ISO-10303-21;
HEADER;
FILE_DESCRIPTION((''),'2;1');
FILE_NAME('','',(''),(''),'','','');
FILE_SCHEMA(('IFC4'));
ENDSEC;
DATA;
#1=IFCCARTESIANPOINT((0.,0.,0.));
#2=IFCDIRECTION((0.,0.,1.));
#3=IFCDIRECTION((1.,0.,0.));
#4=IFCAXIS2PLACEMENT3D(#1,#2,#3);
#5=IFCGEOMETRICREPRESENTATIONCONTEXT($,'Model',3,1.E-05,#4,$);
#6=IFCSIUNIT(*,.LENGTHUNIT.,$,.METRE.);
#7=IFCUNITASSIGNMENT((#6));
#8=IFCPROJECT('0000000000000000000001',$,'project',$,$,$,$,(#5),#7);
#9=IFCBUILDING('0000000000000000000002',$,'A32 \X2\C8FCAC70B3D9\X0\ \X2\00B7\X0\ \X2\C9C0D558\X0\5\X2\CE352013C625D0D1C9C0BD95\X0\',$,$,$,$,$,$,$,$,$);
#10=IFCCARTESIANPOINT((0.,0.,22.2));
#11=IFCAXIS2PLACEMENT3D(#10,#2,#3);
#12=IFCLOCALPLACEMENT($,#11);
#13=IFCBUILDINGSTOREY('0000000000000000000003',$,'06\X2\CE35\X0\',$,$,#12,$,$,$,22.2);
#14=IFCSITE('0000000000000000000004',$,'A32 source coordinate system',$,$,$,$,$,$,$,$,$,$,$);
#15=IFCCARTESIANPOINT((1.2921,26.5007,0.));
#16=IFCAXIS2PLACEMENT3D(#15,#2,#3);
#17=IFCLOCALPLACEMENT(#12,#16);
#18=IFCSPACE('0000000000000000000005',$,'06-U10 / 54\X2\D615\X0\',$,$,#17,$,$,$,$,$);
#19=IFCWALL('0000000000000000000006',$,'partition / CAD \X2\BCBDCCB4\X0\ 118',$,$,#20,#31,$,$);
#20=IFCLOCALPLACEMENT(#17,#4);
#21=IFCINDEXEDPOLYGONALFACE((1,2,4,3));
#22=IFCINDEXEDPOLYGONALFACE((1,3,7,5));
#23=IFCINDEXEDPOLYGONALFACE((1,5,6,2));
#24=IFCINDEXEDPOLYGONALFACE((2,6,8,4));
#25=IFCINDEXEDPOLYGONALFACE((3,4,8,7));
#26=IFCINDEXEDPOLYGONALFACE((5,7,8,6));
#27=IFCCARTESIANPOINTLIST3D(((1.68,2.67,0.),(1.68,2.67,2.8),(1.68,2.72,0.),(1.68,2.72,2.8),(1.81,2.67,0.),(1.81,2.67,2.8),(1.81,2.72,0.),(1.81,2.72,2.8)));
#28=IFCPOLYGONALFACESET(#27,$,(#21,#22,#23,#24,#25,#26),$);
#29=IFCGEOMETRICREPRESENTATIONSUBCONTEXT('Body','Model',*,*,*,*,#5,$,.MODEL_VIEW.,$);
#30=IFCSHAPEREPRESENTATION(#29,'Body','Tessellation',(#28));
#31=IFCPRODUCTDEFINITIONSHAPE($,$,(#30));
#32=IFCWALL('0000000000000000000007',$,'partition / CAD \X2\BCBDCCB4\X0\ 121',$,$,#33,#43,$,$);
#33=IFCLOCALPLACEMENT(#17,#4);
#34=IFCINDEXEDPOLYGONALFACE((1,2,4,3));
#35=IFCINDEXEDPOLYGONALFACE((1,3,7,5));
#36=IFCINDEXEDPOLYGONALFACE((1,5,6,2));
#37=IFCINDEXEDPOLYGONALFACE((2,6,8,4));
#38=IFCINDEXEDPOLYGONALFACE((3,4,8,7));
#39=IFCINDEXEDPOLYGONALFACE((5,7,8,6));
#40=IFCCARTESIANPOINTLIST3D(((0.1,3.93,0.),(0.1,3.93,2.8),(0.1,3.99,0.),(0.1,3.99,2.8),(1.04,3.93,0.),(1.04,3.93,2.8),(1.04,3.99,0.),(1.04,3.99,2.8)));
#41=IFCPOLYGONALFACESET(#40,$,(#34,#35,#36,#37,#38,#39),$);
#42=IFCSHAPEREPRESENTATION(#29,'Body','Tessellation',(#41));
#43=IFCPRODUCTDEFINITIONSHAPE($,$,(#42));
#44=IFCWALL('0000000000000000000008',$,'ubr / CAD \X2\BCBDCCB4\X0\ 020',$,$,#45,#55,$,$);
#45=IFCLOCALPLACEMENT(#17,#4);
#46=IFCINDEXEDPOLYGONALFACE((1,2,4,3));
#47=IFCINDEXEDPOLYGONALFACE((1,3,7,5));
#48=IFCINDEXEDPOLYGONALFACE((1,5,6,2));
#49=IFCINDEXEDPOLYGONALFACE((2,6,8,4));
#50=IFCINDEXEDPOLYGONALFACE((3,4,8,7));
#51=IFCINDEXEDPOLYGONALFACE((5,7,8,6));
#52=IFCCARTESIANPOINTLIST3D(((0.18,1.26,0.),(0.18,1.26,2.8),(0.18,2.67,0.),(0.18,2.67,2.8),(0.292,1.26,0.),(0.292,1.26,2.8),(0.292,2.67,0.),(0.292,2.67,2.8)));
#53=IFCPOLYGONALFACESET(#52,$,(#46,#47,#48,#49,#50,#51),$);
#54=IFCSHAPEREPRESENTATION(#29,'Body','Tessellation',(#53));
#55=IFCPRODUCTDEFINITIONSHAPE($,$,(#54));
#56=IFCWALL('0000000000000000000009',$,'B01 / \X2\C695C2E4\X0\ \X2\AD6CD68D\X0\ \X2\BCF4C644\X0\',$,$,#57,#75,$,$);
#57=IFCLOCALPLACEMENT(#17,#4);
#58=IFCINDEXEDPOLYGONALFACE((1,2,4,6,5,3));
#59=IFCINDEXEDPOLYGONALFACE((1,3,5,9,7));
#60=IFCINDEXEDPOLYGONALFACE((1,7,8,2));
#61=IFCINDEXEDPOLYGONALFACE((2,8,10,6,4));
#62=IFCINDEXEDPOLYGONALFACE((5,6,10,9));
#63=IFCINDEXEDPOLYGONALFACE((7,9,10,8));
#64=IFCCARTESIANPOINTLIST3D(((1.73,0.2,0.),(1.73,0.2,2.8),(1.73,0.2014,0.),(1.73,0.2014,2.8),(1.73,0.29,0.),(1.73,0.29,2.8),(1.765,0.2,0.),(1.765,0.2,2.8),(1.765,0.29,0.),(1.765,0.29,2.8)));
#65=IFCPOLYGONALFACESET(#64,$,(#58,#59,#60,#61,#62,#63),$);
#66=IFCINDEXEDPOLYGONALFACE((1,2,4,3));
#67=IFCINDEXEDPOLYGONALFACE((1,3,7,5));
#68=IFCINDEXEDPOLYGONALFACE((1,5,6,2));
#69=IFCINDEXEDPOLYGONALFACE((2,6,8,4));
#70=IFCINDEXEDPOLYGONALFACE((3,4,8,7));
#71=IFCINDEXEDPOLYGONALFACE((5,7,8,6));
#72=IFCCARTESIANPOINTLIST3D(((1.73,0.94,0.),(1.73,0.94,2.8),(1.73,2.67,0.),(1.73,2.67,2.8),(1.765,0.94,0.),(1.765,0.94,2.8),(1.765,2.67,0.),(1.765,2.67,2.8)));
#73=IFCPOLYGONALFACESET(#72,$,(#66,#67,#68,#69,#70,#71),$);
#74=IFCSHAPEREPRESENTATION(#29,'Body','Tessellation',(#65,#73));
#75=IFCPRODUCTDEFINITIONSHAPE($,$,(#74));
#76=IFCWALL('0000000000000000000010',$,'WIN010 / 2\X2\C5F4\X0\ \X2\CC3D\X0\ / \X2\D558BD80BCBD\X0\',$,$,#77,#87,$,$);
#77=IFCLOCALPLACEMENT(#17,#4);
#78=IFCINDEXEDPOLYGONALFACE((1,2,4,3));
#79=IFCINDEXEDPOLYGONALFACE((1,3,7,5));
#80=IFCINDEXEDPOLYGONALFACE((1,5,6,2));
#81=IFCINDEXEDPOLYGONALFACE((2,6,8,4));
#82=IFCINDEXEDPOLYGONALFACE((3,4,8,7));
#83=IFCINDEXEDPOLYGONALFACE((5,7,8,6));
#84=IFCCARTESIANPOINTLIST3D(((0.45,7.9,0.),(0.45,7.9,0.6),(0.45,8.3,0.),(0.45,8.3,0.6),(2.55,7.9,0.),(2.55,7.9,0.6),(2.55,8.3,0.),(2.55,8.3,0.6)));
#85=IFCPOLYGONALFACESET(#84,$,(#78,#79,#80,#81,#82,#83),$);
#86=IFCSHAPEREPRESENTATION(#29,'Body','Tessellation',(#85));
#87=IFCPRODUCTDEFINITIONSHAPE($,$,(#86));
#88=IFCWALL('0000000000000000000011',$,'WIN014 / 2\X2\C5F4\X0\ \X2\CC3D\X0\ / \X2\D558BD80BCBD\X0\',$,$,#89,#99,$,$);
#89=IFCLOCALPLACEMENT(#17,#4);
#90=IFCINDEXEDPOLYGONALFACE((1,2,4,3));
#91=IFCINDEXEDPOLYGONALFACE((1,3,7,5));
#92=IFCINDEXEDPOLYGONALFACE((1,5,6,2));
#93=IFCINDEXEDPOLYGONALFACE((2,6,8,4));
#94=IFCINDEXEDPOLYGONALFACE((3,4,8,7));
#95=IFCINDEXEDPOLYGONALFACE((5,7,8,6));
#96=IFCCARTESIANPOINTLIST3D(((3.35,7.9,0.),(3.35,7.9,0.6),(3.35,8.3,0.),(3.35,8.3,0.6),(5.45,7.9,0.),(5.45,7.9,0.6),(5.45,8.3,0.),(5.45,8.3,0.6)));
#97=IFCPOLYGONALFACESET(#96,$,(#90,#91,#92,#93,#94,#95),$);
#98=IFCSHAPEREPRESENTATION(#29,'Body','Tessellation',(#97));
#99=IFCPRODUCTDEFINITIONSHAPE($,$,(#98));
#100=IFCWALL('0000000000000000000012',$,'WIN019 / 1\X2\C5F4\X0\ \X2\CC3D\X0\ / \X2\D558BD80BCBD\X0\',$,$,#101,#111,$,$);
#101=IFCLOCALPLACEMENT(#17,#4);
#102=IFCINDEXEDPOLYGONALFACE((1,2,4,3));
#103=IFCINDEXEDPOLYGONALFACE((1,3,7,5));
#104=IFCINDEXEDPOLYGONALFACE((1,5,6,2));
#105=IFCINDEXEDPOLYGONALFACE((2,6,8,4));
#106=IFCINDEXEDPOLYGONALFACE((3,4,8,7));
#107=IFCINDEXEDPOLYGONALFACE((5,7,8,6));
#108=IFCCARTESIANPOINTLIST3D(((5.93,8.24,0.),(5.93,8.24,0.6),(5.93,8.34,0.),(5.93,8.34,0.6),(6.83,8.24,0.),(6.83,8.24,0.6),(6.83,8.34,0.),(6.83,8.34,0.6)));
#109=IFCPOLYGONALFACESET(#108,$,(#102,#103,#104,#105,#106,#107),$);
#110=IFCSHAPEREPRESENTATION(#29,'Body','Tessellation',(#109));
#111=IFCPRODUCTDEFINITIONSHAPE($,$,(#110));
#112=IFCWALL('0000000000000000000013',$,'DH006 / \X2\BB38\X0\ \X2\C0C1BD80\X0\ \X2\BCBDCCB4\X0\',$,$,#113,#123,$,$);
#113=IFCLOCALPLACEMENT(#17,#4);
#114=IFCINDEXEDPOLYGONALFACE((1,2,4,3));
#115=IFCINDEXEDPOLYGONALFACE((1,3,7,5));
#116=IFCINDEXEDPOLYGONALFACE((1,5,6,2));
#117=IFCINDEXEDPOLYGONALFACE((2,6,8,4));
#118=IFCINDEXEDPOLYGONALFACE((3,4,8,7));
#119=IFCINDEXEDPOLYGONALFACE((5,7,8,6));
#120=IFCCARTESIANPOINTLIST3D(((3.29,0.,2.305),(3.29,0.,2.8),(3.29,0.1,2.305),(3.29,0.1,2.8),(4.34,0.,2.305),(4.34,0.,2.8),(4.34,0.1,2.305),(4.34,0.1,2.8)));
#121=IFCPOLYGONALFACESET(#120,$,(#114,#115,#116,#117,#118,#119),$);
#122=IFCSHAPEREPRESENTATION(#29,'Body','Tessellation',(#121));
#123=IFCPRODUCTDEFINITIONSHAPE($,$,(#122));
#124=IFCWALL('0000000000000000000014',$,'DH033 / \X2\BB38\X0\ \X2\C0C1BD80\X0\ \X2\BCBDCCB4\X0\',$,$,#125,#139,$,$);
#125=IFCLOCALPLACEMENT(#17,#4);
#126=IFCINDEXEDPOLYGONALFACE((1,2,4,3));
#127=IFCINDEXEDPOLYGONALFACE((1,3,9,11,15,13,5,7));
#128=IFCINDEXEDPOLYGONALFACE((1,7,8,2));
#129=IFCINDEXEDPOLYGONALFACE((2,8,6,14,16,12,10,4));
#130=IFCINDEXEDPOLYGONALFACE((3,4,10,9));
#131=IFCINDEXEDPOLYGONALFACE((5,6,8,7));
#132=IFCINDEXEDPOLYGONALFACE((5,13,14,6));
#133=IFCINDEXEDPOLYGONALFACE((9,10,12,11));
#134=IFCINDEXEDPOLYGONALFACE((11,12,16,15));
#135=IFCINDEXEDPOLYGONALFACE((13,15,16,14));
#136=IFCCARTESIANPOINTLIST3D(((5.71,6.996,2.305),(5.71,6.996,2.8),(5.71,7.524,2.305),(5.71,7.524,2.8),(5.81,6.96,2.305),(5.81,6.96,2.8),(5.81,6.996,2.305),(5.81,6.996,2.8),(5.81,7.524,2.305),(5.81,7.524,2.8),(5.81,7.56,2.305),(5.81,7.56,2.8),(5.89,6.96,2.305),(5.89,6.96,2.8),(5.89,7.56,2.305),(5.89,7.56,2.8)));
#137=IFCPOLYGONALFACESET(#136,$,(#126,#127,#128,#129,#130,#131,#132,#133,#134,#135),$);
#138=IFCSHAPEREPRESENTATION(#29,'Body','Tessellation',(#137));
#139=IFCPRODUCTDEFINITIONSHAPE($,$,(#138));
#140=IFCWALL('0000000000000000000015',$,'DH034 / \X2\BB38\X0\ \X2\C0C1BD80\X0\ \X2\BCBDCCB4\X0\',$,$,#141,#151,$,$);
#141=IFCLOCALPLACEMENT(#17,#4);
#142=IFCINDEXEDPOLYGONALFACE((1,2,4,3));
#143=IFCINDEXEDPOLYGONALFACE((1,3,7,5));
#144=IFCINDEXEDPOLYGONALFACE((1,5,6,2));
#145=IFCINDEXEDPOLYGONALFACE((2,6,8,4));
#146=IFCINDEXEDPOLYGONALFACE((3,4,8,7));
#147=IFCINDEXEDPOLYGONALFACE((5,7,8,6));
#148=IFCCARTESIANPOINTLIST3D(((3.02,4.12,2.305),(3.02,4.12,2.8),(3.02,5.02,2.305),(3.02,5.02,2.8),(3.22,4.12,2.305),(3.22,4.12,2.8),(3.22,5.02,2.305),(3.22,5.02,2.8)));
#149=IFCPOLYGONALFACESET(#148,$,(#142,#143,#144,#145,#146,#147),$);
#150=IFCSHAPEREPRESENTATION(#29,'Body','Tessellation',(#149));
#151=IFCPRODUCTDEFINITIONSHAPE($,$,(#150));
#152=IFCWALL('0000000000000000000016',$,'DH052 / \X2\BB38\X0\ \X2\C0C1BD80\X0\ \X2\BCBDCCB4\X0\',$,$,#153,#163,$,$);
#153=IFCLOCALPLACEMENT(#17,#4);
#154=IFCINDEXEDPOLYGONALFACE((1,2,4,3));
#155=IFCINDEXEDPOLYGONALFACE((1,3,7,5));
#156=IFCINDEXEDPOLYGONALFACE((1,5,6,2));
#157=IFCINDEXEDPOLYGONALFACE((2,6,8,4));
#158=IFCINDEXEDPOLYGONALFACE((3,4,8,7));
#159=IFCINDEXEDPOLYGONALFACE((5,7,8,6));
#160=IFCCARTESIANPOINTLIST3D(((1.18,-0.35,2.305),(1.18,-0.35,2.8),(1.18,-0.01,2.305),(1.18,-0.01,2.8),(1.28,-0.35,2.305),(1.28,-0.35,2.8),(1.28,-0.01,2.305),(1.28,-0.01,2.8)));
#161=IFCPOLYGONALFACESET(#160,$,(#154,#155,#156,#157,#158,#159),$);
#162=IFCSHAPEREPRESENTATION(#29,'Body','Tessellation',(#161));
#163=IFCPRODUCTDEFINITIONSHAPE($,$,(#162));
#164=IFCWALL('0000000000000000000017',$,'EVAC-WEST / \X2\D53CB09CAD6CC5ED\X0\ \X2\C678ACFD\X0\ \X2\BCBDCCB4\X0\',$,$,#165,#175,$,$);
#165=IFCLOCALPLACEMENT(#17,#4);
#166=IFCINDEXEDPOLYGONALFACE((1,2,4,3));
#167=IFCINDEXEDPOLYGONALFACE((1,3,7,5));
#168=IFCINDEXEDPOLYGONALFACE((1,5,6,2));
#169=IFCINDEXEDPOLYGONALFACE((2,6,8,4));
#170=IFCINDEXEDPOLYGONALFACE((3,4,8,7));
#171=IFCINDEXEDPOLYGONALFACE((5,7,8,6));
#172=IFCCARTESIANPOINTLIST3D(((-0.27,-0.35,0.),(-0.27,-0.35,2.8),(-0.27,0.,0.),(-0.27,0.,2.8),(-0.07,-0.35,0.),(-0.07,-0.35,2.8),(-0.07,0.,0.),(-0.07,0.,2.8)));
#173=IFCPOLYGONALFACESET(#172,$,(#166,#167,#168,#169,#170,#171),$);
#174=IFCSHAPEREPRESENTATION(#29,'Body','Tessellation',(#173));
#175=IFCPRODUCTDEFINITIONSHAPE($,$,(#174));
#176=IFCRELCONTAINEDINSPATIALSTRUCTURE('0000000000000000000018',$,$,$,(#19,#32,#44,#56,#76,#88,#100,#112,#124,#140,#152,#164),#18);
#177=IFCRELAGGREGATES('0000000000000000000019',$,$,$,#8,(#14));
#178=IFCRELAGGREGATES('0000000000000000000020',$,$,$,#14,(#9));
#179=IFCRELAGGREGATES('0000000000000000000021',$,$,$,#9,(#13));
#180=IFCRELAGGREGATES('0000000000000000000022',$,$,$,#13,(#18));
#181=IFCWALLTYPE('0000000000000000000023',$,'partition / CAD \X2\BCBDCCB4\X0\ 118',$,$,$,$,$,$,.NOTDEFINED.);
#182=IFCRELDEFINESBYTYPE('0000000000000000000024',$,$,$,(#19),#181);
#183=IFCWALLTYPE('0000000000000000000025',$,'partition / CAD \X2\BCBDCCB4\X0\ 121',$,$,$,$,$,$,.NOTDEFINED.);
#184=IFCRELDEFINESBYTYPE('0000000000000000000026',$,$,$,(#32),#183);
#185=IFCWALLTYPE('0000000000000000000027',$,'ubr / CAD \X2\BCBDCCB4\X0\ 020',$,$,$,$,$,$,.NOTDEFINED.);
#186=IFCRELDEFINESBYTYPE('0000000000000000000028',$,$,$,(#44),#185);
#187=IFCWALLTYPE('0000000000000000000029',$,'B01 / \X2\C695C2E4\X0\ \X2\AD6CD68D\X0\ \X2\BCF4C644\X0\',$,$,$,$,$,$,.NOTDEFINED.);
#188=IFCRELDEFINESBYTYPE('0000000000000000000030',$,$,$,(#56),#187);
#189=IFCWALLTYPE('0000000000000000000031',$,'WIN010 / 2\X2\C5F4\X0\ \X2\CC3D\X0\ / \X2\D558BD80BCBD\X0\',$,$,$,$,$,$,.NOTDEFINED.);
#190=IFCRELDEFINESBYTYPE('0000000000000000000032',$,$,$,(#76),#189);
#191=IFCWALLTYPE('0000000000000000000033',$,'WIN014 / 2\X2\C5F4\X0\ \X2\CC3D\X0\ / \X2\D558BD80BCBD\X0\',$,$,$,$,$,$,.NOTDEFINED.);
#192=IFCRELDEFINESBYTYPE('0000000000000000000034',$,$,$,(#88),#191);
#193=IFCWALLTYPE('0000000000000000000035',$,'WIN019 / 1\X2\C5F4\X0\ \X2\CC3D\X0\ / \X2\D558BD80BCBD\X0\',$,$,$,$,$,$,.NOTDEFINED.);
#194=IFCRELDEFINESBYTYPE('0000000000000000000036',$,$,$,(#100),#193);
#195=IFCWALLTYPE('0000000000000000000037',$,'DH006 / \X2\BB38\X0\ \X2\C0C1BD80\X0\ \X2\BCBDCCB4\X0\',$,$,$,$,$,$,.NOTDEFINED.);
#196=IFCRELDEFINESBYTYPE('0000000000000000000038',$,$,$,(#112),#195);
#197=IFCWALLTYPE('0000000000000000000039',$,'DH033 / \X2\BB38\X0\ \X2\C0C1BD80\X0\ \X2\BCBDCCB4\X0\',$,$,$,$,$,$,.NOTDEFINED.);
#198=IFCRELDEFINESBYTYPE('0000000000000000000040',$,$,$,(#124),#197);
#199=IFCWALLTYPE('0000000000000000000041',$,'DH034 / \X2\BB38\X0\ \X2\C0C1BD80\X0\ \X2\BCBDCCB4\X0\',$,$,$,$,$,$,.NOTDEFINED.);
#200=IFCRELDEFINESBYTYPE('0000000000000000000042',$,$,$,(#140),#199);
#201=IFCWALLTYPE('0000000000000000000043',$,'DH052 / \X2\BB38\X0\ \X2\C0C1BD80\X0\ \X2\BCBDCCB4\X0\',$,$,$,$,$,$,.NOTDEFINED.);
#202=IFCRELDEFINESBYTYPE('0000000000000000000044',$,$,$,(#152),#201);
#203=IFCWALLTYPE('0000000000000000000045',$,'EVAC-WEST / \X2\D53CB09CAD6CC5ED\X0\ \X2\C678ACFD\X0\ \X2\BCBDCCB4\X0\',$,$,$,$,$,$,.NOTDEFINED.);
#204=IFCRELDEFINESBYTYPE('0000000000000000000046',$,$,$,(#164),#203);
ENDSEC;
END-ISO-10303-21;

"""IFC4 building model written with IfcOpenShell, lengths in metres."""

from ifc_helpers import new_model, si_unit, frame, origin, origin_with_axes, place, context, subcontext, project, spatial, polyline, outline, extrude, source, transform, mapped, type_object, type_shapes, element, save


model = new_model("IFC4")

# Units and contexts
model_context = context("Model", 3, precision=1e-05, world=origin_with_axes())
body_context = subcontext(model_context, "Body", "Model", "MODEL_VIEW")
ifc_project = project(units=[si_unit("LENGTHUNIT", "METRE")], contexts=[model_context])

# Site, building, storey, space
site = spatial("IfcSite", under=ifc_project, Name="A32 source coordinate system")
building = spatial("IfcBuilding", under=site, Name="A32 주거동 · 지하5층–옥탑지붕")
storey_placement = place(None, frame((0.0, 0.0, 22.2), z_axis=(0.0, 0.0, 1.0), x_axis=(1.0, 0.0, 0.0)))
storey = spatial("IfcBuildingStorey", under=building, at=storey_placement, Name="06층", Elevation=22.2)
space_placement = place(storey_placement, frame((1.2921, 26.5007, 0.0), z_axis=(0.0, 0.0, 1.0), x_axis=(1.0, 0.0, 0.0)))
space = spatial("IfcSpace", under=storey, at=space_placement, Name="06-U10 / 54형")

# Walls
wall_type_1 = type_object("IfcWallType", Name="partition / CAD 벽체 118", PredefinedType="NOTDEFINED")
shared_shape_1 = source(origin(), body_context, "Body", "SweptSolid", [
    extrude(outline(polyline([(1.81, 2.67), (1.68, 2.67), (1.68, 2.72), (1.81, 2.72), (1.81, 2.67)])), origin(), (0.0, 0.0, 1.0), 2.8),
])
type_shapes(wall_type_1, [shared_shape_1])
wall_1_placement = place(space_placement, origin_with_axes())
element("IfcWall", 1, at=wall_1_placement, inside=space, type_object=wall_type_1, Name="partition / CAD 벽체 118", context=body_context, shape_type="MappedRepresentation", body=[
    mapped(shared_shape_1, transform((0.0, 0.0, 0.0), scale=1.0)),
])
wall_type_2 = type_object("IfcWallType", Name="partition / CAD 벽체 121", PredefinedType="NOTDEFINED")
shared_shape_2 = source(origin(), body_context, "Body", "SweptSolid", [
    extrude(outline(polyline([(0.1, 3.99), (1.04, 3.99), (1.04, 3.93), (0.1, 3.93), (0.1, 3.99)])), origin(), (0.0, 0.0, 1.0), 2.8),
])
type_shapes(wall_type_2, [shared_shape_2])
wall_2_placement = place(space_placement, origin_with_axes())
element("IfcWall", 2, at=wall_2_placement, inside=space, type_object=wall_type_2, Name="partition / CAD 벽체 121", context=body_context, shape_type="MappedRepresentation", body=[
    mapped(shared_shape_2, transform((0.0, 0.0, 0.0), scale=1.0)),
])
wall_type_3 = type_object("IfcWallType", Name="ubr / CAD 벽체 020", PredefinedType="NOTDEFINED")
shared_shape_3 = source(origin(), body_context, "Body", "SweptSolid", [
    extrude(outline(polyline([(0.18, 1.26), (0.18, 2.67), (0.292, 2.67), (0.292, 1.26), (0.18, 1.26)])), origin(), (0.0, 0.0, 1.0), 2.8),
])
type_shapes(wall_type_3, [shared_shape_3])
wall_3_placement = place(space_placement, origin_with_axes())
element("IfcWall", 3, at=wall_3_placement, inside=space, type_object=wall_type_3, Name="ubr / CAD 벽체 020", context=body_context, shape_type="MappedRepresentation", body=[
    mapped(shared_shape_3, transform((0.0, 0.0, 0.0), scale=1.0)),
])
wall_type_4 = type_object("IfcWallType", Name="B01 / 욕실 구획 보완", PredefinedType="NOTDEFINED")
shared_shape_4 = source(origin(), body_context, "Body", "SweptSolid", [
    extrude(outline(polyline([(1.765, 0.2), (1.73, 0.2), (1.73, 0.2014), (1.73, 0.29), (1.765, 0.29), (1.765, 0.2)])), origin(), (0.0, 0.0, 1.0), 2.8),
    extrude(outline(polyline([(1.765, 2.67), (1.765, 0.94), (1.73, 0.94), (1.73, 2.67), (1.765, 2.67)])), origin(), (0.0, 0.0, 1.0), 2.8),
])
type_shapes(wall_type_4, [shared_shape_4])
wall_4_placement = place(space_placement, origin_with_axes())
element("IfcWall", 4, at=wall_4_placement, inside=space, type_object=wall_type_4, Name="B01 / 욕실 구획 보완", context=body_context, shape_type="MappedRepresentation", body=[
    mapped(shared_shape_4, transform((0.0, 0.0, 0.0), scale=1.0)),
])
wall_type_5 = type_object("IfcWallType", Name="WIN010 / 2열 창 / 하부벽", PredefinedType="NOTDEFINED")
shared_shape_5 = source(origin(), body_context, "Body", "SweptSolid", [
    extrude(outline(polyline([(2.55, 8.3), (2.55, 7.9), (0.45, 7.9), (0.45, 8.3), (2.55, 8.3)])), origin(), (0.0, 0.0, 1.0), 0.6),
])
type_shapes(wall_type_5, [shared_shape_5])
wall_5_placement = place(space_placement, origin_with_axes())
element("IfcWall", 5, at=wall_5_placement, inside=space, type_object=wall_type_5, Name="WIN010 / 2열 창 / 하부벽", context=body_context, shape_type="MappedRepresentation", body=[
    mapped(shared_shape_5, transform((0.0, 0.0, 0.0), scale=1.0)),
])
wall_type_6 = type_object("IfcWallType", Name="WIN014 / 2열 창 / 하부벽", PredefinedType="NOTDEFINED")
shared_shape_6 = source(origin(), body_context, "Body", "SweptSolid", [
    extrude(outline(polyline([(5.45, 8.3), (5.45, 7.9), (3.35, 7.9), (3.35, 8.3), (5.45, 8.3)])), origin(), (0.0, 0.0, 1.0), 0.6),
])
type_shapes(wall_type_6, [shared_shape_6])
wall_6_placement = place(space_placement, origin_with_axes())
element("IfcWall", 6, at=wall_6_placement, inside=space, type_object=wall_type_6, Name="WIN014 / 2열 창 / 하부벽", context=body_context, shape_type="MappedRepresentation", body=[
    mapped(shared_shape_6, transform((0.0, 0.0, 0.0), scale=1.0)),
])
wall_type_7 = type_object("IfcWallType", Name="WIN019 / 1열 창 / 하부벽", PredefinedType="NOTDEFINED")
shared_shape_7 = source(origin(), body_context, "Body", "SweptSolid", [
    extrude(outline(polyline([(6.83, 8.34), (6.83, 8.24), (5.93, 8.24), (5.93, 8.34), (6.83, 8.34)])), origin(), (0.0, 0.0, 1.0), 0.6),
])
type_shapes(wall_type_7, [shared_shape_7])
wall_7_placement = place(space_placement, origin_with_axes())
element("IfcWall", 7, at=wall_7_placement, inside=space, type_object=wall_type_7, Name="WIN019 / 1열 창 / 하부벽", context=body_context, shape_type="MappedRepresentation", body=[
    mapped(shared_shape_7, transform((0.0, 0.0, 0.0), scale=1.0)),
])
wall_type_8 = type_object("IfcWallType", Name="DH006 / 문 상부 벽체", PredefinedType="NOTDEFINED")
shared_shape_8 = source(origin(), body_context, "Body", "SweptSolid", [
    extrude(outline(polyline([(4.34, 0.0), (3.29, 0.0), (3.29, 0.1), (4.34, 0.1), (4.34, 0.0)])), frame((0.0, 0.0, 2.305)), (0.0, 0.0, 1.0), 0.495),
])
type_shapes(wall_type_8, [shared_shape_8])
wall_8_placement = place(space_placement, origin_with_axes())
element("IfcWall", 8, at=wall_8_placement, inside=space, type_object=wall_type_8, Name="DH006 / 문 상부 벽체", context=body_context, shape_type="MappedRepresentation", body=[
    mapped(shared_shape_8, transform((0.0, 0.0, 0.0), scale=1.0)),
])
wall_type_9 = type_object("IfcWallType", Name="DH033 / 문 상부 벽체", PredefinedType="NOTDEFINED")
shared_shape_9 = source(origin(), body_context, "Body", "SweptSolid", [
    extrude(outline(polyline([(5.81, 6.996), (5.71, 6.996), (5.71, 7.524), (5.81, 7.524), (5.81, 7.56), (5.89, 7.56), (5.89, 6.96), (5.81, 6.96), (5.81, 6.996)])), frame((0.0, 0.0, 2.305)), (0.0, 0.0, 1.0), 0.495),
])
type_shapes(wall_type_9, [shared_shape_9])
wall_9_placement = place(space_placement, origin_with_axes())
element("IfcWall", 9, at=wall_9_placement, inside=space, type_object=wall_type_9, Name="DH033 / 문 상부 벽체", context=body_context, shape_type="MappedRepresentation", body=[
    mapped(shared_shape_9, transform((0.0, 0.0, 0.0), scale=1.0)),
])
wall_type_10 = type_object("IfcWallType", Name="DH034 / 문 상부 벽체", PredefinedType="NOTDEFINED")
shared_shape_10 = source(origin(), body_context, "Body", "SweptSolid", [
    extrude(outline(polyline([(3.22, 4.12), (3.02, 4.12), (3.02, 5.02), (3.22, 5.02), (3.22, 4.12)])), frame((0.0, 0.0, 2.305)), (0.0, 0.0, 1.0), 0.495),
])
type_shapes(wall_type_10, [shared_shape_10])
wall_10_placement = place(space_placement, origin_with_axes())
element("IfcWall", 10, at=wall_10_placement, inside=space, type_object=wall_type_10, Name="DH034 / 문 상부 벽체", context=body_context, shape_type="MappedRepresentation", body=[
    mapped(shared_shape_10, transform((0.0, 0.0, 0.0), scale=1.0)),
])
wall_type_11 = type_object("IfcWallType", Name="DH052 / 문 상부 벽체", PredefinedType="NOTDEFINED")
shared_shape_11 = source(origin(), body_context, "Body", "SweptSolid", [
    extrude(outline(polyline([(1.28, -0.35), (1.18, -0.35), (1.18, -0.01), (1.28, -0.01), (1.28, -0.35)])), frame((0.0, 0.0, 2.305)), (0.0, 0.0, 1.0), 0.495),
])
type_shapes(wall_type_11, [shared_shape_11])
wall_11_placement = place(space_placement, origin_with_axes())
element("IfcWall", 11, at=wall_11_placement, inside=space, type_object=wall_type_11, Name="DH052 / 문 상부 벽체", context=body_context, shape_type="MappedRepresentation", body=[
    mapped(shared_shape_11, transform((0.0, 0.0, 0.0), scale=1.0)),
])
wall_type_12 = type_object("IfcWallType", Name="EVAC-WEST / 피난구역 외곽 벽체", PredefinedType="NOTDEFINED")
shared_shape_12 = source(origin(), body_context, "Body", "SweptSolid", [
    extrude(outline(polyline([(-0.07, 0.0), (-0.07, -0.35), (-0.27, -0.35), (-0.27, 0.0), (-0.07, 0.0)])), origin(), (0.0, 0.0, 1.0), 2.8),
])
type_shapes(wall_type_12, [shared_shape_12])
wall_12_placement = place(space_placement, origin_with_axes())
element("IfcWall", 12, at=wall_12_placement, inside=space, type_object=wall_type_12, Name="EVAC-WEST / 피난구역 외곽 벽체", context=body_context, shape_type="MappedRepresentation", body=[
    mapped(shared_shape_12, transform((0.0, 0.0, 0.0), scale=1.0)),
])

save(model, "model.ifc")
